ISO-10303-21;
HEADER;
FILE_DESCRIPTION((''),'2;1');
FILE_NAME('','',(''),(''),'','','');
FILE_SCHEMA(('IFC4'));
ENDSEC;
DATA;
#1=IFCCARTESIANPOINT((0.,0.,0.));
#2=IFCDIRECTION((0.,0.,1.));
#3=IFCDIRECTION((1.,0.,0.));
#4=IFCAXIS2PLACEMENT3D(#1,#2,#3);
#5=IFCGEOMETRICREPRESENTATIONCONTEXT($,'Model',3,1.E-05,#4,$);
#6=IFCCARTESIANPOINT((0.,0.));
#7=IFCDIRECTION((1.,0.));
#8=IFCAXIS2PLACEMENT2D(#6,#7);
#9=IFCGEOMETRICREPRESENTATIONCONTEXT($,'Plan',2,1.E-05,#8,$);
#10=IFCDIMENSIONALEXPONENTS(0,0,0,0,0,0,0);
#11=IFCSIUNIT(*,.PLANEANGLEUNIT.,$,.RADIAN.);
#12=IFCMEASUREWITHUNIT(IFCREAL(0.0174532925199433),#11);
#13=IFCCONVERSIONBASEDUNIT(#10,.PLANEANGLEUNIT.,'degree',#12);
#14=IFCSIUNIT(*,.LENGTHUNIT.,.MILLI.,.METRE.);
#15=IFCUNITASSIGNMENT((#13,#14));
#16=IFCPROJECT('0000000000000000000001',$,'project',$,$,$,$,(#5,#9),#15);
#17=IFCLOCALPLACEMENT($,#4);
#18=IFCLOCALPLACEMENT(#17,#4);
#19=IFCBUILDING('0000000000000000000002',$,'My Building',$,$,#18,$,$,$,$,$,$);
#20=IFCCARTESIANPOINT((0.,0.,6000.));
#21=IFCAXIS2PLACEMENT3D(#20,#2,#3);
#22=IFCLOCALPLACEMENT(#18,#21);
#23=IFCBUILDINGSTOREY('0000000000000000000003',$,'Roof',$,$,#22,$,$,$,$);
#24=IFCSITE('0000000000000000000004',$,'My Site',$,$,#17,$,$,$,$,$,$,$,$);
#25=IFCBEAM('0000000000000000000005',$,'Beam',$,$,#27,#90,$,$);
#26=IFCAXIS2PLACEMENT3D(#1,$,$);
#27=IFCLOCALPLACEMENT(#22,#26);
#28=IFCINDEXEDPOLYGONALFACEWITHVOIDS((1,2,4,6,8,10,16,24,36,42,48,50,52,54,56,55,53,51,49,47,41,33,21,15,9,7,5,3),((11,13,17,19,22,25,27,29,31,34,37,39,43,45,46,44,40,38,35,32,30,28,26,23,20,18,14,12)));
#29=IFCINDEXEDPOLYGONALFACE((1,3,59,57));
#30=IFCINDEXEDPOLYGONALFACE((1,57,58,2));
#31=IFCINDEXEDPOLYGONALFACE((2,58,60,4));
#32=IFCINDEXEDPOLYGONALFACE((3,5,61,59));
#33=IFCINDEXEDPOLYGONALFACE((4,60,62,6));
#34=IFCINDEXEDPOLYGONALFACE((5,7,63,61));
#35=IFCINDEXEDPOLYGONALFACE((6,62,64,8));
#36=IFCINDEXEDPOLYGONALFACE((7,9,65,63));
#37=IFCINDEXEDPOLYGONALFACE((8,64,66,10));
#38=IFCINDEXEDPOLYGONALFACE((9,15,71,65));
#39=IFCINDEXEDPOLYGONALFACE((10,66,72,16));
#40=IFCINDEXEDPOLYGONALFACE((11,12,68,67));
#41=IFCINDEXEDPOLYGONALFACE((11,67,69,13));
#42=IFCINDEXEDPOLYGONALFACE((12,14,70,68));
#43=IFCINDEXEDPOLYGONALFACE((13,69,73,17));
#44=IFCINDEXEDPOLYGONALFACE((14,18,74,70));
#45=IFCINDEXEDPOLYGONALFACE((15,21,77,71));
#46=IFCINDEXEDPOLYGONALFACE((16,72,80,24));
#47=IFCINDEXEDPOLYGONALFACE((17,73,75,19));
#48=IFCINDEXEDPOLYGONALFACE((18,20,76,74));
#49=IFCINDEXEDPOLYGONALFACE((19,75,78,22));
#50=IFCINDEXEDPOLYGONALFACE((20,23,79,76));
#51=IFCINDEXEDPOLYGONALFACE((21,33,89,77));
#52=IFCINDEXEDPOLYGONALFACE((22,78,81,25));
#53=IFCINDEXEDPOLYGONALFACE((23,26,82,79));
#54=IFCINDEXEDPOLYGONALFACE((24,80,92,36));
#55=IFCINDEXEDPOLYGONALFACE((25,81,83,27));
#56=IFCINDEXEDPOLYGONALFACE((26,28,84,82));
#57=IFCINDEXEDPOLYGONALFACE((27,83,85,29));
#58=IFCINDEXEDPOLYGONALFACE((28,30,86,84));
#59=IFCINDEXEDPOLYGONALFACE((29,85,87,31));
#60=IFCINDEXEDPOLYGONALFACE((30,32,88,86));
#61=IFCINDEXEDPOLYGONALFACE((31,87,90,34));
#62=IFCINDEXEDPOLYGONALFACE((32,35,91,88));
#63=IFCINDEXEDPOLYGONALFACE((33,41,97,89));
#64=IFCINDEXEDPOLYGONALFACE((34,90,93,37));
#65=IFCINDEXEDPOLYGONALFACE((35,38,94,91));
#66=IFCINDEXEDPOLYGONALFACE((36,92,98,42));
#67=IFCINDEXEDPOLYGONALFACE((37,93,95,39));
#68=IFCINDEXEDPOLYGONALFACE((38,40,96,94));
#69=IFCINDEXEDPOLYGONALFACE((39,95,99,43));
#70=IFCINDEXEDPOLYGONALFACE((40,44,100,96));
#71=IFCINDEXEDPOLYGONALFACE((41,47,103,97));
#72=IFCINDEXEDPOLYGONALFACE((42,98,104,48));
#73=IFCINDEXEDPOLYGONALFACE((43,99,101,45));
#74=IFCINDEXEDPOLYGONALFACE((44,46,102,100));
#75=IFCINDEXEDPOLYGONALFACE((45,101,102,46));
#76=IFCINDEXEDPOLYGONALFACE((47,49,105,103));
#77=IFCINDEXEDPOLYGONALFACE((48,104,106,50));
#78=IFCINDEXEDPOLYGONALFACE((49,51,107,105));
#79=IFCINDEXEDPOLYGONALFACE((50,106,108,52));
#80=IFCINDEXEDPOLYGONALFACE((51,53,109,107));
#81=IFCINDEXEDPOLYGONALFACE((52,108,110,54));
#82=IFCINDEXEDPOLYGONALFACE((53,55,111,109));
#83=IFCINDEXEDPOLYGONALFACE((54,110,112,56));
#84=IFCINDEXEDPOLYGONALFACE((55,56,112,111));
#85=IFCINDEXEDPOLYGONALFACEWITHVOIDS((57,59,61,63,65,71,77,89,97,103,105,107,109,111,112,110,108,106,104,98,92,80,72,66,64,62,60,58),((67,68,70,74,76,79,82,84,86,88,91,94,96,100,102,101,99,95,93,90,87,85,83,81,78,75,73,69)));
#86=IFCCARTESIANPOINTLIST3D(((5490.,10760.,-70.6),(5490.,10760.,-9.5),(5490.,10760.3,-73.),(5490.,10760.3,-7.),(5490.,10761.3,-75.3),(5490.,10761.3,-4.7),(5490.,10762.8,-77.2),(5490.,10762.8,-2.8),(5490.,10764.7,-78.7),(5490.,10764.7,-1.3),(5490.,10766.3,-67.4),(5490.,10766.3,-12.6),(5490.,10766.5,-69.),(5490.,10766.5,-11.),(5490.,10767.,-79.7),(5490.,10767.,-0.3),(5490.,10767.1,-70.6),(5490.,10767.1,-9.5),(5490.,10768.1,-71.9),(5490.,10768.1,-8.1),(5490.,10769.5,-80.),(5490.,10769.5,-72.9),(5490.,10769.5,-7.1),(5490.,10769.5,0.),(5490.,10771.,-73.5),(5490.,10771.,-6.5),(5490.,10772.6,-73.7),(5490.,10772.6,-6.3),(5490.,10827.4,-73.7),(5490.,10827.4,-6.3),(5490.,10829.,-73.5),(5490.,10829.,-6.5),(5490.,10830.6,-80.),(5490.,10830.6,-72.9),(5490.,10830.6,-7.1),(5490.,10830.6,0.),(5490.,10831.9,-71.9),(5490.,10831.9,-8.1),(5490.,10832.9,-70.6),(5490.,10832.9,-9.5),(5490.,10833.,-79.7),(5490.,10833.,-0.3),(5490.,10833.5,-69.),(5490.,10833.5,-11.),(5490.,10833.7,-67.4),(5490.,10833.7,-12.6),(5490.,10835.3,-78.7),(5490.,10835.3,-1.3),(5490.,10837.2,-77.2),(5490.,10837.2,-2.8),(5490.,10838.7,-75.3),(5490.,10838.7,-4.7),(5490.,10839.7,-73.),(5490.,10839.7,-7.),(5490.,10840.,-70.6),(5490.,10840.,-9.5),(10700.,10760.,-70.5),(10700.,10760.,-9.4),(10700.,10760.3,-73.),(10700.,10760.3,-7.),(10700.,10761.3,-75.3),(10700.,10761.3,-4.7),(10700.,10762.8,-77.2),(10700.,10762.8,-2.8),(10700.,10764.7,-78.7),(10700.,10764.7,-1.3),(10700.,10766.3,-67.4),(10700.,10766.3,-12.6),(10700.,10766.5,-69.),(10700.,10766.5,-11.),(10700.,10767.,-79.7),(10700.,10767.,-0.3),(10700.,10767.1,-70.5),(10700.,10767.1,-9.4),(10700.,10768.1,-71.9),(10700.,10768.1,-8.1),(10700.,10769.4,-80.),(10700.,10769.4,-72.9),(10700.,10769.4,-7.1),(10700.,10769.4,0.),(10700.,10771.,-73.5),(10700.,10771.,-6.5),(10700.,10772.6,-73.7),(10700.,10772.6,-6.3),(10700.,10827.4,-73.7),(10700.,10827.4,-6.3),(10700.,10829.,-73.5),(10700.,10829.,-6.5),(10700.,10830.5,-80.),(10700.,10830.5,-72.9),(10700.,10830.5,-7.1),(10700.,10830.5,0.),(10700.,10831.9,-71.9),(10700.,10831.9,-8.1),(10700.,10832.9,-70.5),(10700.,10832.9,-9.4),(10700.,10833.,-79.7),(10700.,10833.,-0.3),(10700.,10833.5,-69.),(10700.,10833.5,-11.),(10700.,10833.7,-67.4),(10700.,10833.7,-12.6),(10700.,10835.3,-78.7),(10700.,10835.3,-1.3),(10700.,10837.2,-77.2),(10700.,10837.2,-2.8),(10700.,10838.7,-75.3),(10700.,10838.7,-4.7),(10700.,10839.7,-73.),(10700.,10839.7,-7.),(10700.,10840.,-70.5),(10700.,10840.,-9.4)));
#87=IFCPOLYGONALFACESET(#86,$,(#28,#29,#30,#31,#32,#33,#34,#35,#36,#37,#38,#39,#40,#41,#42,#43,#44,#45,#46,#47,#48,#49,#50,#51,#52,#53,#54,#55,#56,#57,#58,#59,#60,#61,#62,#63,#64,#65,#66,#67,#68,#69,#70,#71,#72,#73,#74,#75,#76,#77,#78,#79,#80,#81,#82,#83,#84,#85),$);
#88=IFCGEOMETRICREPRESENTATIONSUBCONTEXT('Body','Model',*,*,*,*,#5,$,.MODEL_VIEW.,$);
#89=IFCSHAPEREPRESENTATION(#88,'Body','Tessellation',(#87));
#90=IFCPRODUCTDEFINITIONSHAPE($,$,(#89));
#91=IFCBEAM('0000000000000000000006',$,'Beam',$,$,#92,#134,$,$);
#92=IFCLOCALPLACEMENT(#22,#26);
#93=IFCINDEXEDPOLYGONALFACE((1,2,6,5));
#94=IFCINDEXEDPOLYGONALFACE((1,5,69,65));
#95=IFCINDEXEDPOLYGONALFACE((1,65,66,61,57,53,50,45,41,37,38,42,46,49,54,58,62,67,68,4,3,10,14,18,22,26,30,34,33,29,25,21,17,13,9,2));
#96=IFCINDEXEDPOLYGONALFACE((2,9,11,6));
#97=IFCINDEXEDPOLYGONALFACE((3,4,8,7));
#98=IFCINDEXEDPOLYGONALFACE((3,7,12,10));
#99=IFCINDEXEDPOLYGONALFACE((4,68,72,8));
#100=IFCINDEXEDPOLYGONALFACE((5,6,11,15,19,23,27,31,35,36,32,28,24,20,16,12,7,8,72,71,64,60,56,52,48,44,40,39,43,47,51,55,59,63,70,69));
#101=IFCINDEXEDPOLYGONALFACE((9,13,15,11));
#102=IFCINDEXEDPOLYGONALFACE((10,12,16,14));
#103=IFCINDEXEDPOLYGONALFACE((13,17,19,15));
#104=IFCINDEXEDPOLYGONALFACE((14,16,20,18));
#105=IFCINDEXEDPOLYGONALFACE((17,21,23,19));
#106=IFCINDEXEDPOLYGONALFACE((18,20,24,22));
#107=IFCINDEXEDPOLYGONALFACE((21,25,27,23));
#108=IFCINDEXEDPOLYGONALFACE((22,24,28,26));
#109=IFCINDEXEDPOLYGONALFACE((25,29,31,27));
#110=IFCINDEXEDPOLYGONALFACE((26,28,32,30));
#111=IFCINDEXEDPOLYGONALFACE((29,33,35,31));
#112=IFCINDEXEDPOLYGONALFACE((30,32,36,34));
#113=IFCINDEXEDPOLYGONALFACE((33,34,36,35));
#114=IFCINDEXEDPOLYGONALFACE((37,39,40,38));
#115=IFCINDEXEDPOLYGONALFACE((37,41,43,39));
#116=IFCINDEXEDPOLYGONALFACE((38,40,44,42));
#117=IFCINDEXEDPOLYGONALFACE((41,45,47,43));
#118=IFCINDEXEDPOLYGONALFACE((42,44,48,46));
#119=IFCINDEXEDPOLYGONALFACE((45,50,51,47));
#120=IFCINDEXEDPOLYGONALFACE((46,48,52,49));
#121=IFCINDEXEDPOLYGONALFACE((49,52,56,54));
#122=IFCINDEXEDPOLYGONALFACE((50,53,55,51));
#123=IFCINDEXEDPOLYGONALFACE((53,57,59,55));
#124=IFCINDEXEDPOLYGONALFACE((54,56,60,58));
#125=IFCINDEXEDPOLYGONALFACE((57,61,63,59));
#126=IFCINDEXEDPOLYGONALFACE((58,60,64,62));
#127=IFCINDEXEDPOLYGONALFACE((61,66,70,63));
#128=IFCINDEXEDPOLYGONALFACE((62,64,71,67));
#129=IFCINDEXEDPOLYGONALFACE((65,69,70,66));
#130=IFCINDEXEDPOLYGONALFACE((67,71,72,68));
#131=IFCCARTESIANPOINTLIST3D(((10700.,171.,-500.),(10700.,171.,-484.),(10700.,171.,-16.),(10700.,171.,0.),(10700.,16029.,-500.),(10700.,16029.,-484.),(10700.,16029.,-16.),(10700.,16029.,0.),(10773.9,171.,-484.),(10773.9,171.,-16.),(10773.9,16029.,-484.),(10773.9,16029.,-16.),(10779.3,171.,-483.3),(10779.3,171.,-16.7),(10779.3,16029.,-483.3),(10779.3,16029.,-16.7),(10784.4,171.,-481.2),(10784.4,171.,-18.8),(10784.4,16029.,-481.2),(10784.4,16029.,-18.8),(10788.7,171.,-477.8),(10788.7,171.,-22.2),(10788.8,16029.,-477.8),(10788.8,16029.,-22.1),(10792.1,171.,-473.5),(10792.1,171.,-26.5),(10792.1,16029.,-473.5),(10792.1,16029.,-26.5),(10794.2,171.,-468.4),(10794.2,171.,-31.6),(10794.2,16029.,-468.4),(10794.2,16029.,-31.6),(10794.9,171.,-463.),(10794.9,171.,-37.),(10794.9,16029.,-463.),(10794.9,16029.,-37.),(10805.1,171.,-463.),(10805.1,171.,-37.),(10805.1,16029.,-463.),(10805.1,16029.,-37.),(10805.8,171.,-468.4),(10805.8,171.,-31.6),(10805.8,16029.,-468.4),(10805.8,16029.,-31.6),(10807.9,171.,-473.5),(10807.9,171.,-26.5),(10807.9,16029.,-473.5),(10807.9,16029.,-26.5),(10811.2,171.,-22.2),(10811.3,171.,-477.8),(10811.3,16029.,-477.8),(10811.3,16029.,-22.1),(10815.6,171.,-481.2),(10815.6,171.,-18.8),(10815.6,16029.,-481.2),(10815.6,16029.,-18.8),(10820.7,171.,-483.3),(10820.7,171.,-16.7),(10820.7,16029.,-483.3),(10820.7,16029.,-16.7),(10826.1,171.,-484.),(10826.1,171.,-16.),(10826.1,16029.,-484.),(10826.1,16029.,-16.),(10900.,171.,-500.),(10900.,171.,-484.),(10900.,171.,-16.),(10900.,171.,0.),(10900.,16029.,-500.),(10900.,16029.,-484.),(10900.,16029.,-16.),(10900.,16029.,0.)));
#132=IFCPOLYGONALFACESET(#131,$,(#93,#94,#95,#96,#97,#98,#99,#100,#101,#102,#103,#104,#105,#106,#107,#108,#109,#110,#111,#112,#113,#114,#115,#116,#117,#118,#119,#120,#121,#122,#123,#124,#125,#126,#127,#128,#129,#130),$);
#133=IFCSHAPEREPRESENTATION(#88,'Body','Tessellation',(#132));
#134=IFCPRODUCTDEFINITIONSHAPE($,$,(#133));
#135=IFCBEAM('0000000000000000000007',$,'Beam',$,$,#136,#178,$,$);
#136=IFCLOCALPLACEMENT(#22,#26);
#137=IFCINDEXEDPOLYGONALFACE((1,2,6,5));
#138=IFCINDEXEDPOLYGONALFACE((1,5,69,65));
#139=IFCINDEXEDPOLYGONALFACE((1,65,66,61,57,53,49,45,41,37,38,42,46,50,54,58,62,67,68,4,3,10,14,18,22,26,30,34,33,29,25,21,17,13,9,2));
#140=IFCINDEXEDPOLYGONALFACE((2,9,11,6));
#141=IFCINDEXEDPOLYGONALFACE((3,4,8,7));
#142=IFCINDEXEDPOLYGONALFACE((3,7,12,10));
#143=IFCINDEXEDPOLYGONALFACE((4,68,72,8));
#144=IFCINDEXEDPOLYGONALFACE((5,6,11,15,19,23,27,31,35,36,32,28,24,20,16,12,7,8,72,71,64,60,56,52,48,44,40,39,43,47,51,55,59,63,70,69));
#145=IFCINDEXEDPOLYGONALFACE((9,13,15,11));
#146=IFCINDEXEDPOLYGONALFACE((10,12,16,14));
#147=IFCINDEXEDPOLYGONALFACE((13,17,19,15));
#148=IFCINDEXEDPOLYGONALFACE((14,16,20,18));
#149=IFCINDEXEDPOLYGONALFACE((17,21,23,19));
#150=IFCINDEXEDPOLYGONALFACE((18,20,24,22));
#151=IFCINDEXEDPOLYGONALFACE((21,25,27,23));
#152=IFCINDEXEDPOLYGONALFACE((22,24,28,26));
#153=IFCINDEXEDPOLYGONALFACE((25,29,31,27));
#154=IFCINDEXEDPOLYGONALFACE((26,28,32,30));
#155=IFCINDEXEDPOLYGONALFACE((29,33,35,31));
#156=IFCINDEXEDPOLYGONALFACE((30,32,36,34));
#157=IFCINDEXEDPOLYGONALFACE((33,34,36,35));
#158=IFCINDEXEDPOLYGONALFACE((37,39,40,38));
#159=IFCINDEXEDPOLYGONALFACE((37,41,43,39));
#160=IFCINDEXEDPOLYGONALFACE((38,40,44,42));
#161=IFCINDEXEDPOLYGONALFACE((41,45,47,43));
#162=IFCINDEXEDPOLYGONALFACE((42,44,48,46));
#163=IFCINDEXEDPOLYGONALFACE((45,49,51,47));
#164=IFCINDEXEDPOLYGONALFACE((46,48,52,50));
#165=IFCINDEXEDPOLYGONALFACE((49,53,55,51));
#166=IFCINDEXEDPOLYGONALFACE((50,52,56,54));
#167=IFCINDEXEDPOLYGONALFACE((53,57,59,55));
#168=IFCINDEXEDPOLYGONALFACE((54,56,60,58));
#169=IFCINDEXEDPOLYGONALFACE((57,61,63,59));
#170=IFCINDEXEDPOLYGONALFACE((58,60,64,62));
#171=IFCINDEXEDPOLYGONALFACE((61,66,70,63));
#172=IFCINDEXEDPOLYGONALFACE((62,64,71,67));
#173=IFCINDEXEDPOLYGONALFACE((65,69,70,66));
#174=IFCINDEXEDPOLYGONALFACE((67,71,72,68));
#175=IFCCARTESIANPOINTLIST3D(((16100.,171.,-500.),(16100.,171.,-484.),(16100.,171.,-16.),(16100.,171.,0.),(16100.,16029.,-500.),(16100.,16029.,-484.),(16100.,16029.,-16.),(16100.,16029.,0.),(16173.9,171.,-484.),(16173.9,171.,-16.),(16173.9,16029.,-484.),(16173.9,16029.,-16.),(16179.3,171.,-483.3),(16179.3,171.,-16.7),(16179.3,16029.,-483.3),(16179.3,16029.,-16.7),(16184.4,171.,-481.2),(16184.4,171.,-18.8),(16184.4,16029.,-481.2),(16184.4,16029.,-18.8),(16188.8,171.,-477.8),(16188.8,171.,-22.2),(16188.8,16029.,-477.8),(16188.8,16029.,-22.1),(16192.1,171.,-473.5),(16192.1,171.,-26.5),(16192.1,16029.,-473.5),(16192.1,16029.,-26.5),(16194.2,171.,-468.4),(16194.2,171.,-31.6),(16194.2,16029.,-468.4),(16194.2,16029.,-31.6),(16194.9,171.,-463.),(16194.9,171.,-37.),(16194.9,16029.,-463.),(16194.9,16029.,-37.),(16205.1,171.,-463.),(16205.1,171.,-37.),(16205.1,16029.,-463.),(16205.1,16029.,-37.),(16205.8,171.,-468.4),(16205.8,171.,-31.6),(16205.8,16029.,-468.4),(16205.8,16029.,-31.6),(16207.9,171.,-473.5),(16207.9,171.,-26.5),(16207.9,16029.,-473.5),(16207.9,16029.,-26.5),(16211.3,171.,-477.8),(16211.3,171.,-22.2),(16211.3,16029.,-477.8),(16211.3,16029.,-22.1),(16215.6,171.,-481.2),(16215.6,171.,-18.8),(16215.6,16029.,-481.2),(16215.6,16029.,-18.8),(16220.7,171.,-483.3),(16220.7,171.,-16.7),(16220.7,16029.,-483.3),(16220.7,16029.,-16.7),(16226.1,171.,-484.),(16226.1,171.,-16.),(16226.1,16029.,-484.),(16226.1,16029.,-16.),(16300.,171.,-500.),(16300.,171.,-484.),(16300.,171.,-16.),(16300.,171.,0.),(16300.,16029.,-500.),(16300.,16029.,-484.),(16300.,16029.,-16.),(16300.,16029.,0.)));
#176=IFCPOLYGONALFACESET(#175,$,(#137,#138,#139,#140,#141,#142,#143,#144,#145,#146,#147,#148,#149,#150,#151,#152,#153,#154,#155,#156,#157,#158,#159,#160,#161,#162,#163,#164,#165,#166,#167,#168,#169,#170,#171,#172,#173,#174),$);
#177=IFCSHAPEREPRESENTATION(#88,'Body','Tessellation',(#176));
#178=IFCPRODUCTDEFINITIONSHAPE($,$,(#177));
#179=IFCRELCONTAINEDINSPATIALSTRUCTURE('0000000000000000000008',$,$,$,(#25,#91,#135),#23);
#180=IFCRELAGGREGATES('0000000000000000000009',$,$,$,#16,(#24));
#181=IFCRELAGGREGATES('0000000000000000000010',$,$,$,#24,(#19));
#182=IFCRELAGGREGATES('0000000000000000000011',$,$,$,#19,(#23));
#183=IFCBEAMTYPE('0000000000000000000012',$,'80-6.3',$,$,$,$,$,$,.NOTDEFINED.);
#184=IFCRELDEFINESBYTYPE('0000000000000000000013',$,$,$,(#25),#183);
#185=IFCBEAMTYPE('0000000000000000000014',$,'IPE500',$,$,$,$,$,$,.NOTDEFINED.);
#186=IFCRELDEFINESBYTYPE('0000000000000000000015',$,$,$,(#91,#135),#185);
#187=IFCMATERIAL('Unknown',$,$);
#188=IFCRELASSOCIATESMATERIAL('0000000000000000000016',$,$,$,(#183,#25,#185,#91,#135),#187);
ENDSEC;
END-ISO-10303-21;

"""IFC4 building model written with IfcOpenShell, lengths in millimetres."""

from ifc_helpers import new_model, entity, si_unit, converted_unit, frame, origin_with_axes, origin_2d_with_axis, place, context, subcontext, project, spatial, hollow_rectangle, i_section, extrude, material, material_profile, profile_set, profile_usage, type_object, element, save


model = new_model("IFC4")

# Units and contexts
model_context = context("Model", 3, precision=1e-05, world=origin_with_axes())
plan_context = context("Plan", 2, precision=1e-05, world=origin_2d_with_axis())
body_context = subcontext(model_context, "Body", "Model", "MODEL_VIEW")
ifc_project = project(units=[converted_unit("PLANEANGLEUNIT", "degree", entity("IfcReal", 0.0174532925199433), si_unit("PLANEANGLEUNIT", "RADIAN"), dimensions=[0, 0, 0, 0, 0, 0, 0]), si_unit("LENGTHUNIT", "METRE", prefix="MILLI")], contexts=[model_context, plan_context])

# Site, building, storey
site_placement = place(None, origin_with_axes())
site = spatial("IfcSite", under=ifc_project, at=site_placement, Name="My Site")
building_placement = place(site_placement, origin_with_axes())
building = spatial("IfcBuilding", under=site, at=building_placement, Name="My Building")
storey_placement = place(building_placement, frame((0.0, 0.0, 6000.0), z_axis=(0.0, 0.0, 1.0), x_axis=(1.0, 0.0, 0.0)))
storey = spatial("IfcBuildingStorey", under=building, at=storey_placement, Name="Roof")

# Beams
ifc_material = material(Name="Unknown")
ifc_material_profile_1 = material_profile(ifc_material, hollow_rectangle(XDim=80.0, YDim=80.0, WallThickness=6.3, InnerFilletRadius=6.3, OuterFilletRadius=9.4))
ifc_profile_set_1 = profile_set([ifc_material_profile_1])
beam_type_1 = type_object("IfcBeamType", Name="80-6.3", PredefinedType="NOTDEFINED", material=ifc_profile_set_1)
ifc_profile_usage_1 = profile_usage(ifc_profile_set_1, cardinal=8)
beam_1_placement = place(storey_placement, frame((5490.0, 10800.0, 0.0), z_axis=(1.0, 0.0, 0.0), x_axis=(0.0, 1.0, 0.0)))
element("IfcBeam", 1, at=beam_1_placement, inside=storey, type_object=beam_type_1, material=ifc_profile_usage_1, Name="Beam", context=body_context, shape_type="SweptSolid", body=[
    extrude(hollow_rectangle(XDim=80.0, YDim=80.0, WallThickness=6.3, InnerFilletRadius=6.3, OuterFilletRadius=9.4), frame((0.0, -40.0, 0.0), z_axis=(0.0, 0.0, 1.0), x_axis=(1.0, 0.0, 0.0)), (0.0, 0.0, 1.0), 5210.0),
])
ifc_material_profile_2 = material_profile(ifc_material, i_section(OverallWidth=200.0, OverallDepth=500.0, WebThickness=10.2, FlangeThickness=16.0, FilletRadius=21.0))
ifc_profile_set_2 = profile_set([ifc_material_profile_2])
ifc_profile_usage_2 = profile_usage(ifc_profile_set_2, cardinal=8)
beam_type_2 = type_object("IfcBeamType", Name="IPE500", PredefinedType="NOTDEFINED", material=ifc_profile_set_2)
beam_2_placement = place(storey_placement, frame((10800.0, 171.0, 0.0), z_axis=(0.0, 1.0, 0.0), x_axis=(-1.0, 0.0, 0.0)))
element("IfcBeam", 2, at=beam_2_placement, inside=storey, type_object=beam_type_2, material=ifc_profile_usage_2, Name="Beam", context=body_context, shape_type="SweptSolid", body=[
    extrude(i_section(OverallWidth=200.0, OverallDepth=500.0, WebThickness=10.2, FlangeThickness=16.0, FilletRadius=21.0), frame((0.0, -250.0, 0.0), z_axis=(0.0, 0.0, 1.0), x_axis=(1.0, 0.0, 0.0)), (0.0, 0.0, 1.0), 15858.0),
])
ifc_profile_usage_3 = profile_usage(ifc_profile_set_2, cardinal=8)
beam_3_placement = place(storey_placement, frame((16200.0, 171.0, 0.0), z_axis=(0.0, 1.0, 0.0), x_axis=(-1.0, 0.0, 0.0)))
element("IfcBeam", 3, at=beam_3_placement, inside=storey, type_object=beam_type_2, material=ifc_profile_usage_3, Name="Beam", context=body_context, shape_type="SweptSolid", body=[
    extrude(i_section(OverallWidth=200.0, OverallDepth=500.0, WebThickness=10.2, FlangeThickness=16.0, FilletRadius=21.0), frame((0.0, -250.0, 0.0), z_axis=(0.0, 0.0, 1.0), x_axis=(1.0, 0.0, 0.0)), (0.0, 0.0, 1.0), 15858.0),
])

save(model, "model.ifc")
